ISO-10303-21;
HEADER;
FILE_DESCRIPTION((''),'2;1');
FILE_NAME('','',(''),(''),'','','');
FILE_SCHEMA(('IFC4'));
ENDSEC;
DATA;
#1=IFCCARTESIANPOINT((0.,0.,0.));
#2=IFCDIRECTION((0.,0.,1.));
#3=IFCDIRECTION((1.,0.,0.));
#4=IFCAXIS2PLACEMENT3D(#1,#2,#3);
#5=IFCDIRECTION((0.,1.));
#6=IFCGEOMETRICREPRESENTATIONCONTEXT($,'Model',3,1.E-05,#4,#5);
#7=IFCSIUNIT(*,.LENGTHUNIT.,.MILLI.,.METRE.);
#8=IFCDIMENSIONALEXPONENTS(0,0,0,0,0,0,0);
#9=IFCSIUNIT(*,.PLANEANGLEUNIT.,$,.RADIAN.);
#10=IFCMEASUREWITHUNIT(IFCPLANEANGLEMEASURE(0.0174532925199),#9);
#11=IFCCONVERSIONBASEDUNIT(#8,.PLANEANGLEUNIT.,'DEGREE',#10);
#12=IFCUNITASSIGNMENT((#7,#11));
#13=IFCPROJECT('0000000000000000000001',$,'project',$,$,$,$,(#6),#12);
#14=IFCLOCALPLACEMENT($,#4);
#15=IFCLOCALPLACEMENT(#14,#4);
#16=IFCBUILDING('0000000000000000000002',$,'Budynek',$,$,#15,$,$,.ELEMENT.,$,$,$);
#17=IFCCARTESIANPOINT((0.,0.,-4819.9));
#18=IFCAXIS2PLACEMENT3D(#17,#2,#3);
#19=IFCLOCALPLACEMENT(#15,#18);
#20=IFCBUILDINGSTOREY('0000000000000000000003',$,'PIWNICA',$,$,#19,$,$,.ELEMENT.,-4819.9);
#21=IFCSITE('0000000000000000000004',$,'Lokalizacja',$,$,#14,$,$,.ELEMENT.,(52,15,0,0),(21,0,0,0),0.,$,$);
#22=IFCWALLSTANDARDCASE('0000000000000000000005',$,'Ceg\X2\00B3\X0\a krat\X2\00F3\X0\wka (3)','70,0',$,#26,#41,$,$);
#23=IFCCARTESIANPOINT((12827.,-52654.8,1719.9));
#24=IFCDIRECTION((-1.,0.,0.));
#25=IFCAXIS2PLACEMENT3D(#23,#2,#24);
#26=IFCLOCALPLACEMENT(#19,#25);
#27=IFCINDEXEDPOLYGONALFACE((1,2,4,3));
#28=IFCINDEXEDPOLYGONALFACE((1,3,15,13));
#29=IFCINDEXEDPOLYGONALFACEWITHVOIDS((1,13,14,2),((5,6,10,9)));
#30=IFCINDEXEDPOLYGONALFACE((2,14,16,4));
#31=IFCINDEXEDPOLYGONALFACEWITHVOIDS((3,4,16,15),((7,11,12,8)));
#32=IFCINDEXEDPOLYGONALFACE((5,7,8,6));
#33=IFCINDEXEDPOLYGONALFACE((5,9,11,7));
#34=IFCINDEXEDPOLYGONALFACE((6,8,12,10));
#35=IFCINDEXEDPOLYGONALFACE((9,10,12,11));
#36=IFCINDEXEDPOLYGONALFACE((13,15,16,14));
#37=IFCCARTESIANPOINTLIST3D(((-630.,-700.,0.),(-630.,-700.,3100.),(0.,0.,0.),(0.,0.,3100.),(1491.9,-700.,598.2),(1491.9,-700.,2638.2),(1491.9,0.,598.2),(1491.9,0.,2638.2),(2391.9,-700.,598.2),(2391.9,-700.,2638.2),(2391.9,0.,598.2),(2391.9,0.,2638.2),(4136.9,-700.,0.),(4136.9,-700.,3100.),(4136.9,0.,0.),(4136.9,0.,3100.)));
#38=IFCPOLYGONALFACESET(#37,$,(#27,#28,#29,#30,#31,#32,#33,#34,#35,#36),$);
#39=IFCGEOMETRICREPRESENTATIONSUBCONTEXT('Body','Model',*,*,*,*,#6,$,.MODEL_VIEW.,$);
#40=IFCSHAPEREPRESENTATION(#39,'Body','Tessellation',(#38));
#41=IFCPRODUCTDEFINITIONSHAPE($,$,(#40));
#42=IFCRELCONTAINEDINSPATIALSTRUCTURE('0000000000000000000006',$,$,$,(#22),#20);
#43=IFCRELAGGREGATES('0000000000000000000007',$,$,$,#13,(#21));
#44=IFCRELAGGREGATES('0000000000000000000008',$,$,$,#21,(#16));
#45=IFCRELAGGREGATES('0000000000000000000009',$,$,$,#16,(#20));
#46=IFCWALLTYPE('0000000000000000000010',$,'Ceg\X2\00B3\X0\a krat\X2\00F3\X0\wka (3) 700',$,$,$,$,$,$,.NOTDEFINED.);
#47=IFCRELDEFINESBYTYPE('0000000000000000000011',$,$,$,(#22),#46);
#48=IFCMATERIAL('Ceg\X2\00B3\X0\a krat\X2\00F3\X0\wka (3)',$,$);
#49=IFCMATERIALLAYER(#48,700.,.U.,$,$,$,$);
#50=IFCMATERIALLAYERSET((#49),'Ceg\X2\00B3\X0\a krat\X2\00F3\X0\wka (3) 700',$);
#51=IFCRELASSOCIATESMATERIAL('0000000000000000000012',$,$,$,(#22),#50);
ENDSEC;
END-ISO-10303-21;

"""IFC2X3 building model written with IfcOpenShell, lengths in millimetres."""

from ifc_helpers import new_model, entity, si_unit, converted_unit, direction, frame, origin_with_axes, origin_2d_with_axis, place, context, subcontext, project, spatial, polyline, rectangle, outline, extrude, material, layer, layer_set, layer_usage, type_object, element, save


model = new_model("IFC2X3")

# Units and contexts
model_context = context("Model", 3, precision=1e-05, world=origin_with_axes(), true_north=direction((0.0, 1.0)))
body_context = subcontext(model_context, "Body", "Model", "MODEL_VIEW")
ifc_project = project(units=[si_unit("LENGTHUNIT", "METRE", prefix="MILLI"), converted_unit("PLANEANGLEUNIT", "DEGREE", entity("IfcPlaneAngleMeasure", 0.0174532925199), si_unit("PLANEANGLEUNIT", "RADIAN"), dimensions=[0, 0, 0, 0, 0, 0, 0])], contexts=[model_context])

# Site, building, storey
site_placement = place(None, origin_with_axes())
site = spatial("IfcSite", under=ifc_project, at=site_placement, Name="Lokalizacja", CompositionType="ELEMENT", RefLatitude=(52, 15, 0, 0), RefLongitude=(21, 0, 0, 0), RefElevation=0.0)
building_placement = place(site_placement, origin_with_axes())
building = spatial("IfcBuilding", under=site, at=building_placement, Name="Budynek", CompositionType="ELEMENT")
storey_placement = place(building_placement, frame((0.0, 0.0, -4819.9), z_axis=(0.0, 0.0, 1.0), x_axis=(1.0, 0.0, 0.0)))
storey = spatial("IfcBuildingStorey", under=building, at=storey_placement, Name="PIWNICA", CompositionType="ELEMENT", Elevation=-4819.9)

# Shared definitions
ifc_material_1 = material(Name="Ceg³a kratówka (3)")
ifc_layer_1 = layer(ifc_material_1, 700.0, ventilated="UNKNOWN")
ifc_layer_set_1 = layer_set([ifc_layer_1], Name="Ceg³a kratówka (3) 700")
wall_type_1 = type_object("IfcWallType", Name="Ceg³a kratówka (3) 700", PredefinedType="NOTDEFINED")

# Wall, opening
ifc_layer_usage_1 = layer_usage(ifc_layer_set_1, "AXIS2", "NEGATIVE", 0.0)
wall_1_placement = place(storey_placement, frame((12827.0, -52654.8, 1719.9), z_axis=(0.0, 0.0, 1.0), x_axis=(-1.0, 0.0, 0.0)))
wall_1 = element("IfcWallStandardCase", 1, at=wall_1_placement, inside=storey, type_object=wall_type_1, material=ifc_layer_usage_1, Name="Ceg³a kratówka (3)", Description="70,0", context=body_context, shape_type="SweptSolid", body=[
    extrude(outline(polyline([(-630.0, -700.0), (4136.9, -700.0), (4136.9, 0.0), (0.0, 0.0), (-630.0, -700.0)])), origin_with_axes(), (0.0, 0.0, 1.0), 3100.0),
])
opening_1_placement = place(wall_1_placement, frame((1941.9, 0.0, 598.2), z_axis=(0.0, 0.0, 1.0), x_axis=(1.0, 0.0, 0.0)))
element("IfcOpeningElement", 2, at=opening_1_placement, cuts=wall_1, context=body_context, shape_type="SweptSolid", body=[
    extrude(rectangle(XDim=900.0, YDim=2040.0, at=origin_2d_with_axis()), frame((0.0, 700.0, 1020.0), z_axis=(0.0, -1.0, 0.0), x_axis=(-1.0, 0.0, 0.0)), (0.0, 0.0, 1.0), 2100.0),
    extrude(rectangle(XDim=1060.0, YDim=2060.0, at=origin_2d_with_axis()), frame((0.0, 0.0, 1030.0), z_axis=(0.0, -1.0, 0.0), x_axis=(-1.0, 0.0, 0.0)), (0.0, 0.0, -1.0), 700.0),
    extrude(rectangle(XDim=1020.0, YDim=2060.0, at=origin_2d_with_axis()), frame((0.0, -700.0, 1030.0), z_axis=(0.0, 1.0, 0.0), x_axis=(-1.0, 0.0, 0.0)), (0.0, 0.0, -1.0), 700.0),
])

save(model, "model.ifc")
